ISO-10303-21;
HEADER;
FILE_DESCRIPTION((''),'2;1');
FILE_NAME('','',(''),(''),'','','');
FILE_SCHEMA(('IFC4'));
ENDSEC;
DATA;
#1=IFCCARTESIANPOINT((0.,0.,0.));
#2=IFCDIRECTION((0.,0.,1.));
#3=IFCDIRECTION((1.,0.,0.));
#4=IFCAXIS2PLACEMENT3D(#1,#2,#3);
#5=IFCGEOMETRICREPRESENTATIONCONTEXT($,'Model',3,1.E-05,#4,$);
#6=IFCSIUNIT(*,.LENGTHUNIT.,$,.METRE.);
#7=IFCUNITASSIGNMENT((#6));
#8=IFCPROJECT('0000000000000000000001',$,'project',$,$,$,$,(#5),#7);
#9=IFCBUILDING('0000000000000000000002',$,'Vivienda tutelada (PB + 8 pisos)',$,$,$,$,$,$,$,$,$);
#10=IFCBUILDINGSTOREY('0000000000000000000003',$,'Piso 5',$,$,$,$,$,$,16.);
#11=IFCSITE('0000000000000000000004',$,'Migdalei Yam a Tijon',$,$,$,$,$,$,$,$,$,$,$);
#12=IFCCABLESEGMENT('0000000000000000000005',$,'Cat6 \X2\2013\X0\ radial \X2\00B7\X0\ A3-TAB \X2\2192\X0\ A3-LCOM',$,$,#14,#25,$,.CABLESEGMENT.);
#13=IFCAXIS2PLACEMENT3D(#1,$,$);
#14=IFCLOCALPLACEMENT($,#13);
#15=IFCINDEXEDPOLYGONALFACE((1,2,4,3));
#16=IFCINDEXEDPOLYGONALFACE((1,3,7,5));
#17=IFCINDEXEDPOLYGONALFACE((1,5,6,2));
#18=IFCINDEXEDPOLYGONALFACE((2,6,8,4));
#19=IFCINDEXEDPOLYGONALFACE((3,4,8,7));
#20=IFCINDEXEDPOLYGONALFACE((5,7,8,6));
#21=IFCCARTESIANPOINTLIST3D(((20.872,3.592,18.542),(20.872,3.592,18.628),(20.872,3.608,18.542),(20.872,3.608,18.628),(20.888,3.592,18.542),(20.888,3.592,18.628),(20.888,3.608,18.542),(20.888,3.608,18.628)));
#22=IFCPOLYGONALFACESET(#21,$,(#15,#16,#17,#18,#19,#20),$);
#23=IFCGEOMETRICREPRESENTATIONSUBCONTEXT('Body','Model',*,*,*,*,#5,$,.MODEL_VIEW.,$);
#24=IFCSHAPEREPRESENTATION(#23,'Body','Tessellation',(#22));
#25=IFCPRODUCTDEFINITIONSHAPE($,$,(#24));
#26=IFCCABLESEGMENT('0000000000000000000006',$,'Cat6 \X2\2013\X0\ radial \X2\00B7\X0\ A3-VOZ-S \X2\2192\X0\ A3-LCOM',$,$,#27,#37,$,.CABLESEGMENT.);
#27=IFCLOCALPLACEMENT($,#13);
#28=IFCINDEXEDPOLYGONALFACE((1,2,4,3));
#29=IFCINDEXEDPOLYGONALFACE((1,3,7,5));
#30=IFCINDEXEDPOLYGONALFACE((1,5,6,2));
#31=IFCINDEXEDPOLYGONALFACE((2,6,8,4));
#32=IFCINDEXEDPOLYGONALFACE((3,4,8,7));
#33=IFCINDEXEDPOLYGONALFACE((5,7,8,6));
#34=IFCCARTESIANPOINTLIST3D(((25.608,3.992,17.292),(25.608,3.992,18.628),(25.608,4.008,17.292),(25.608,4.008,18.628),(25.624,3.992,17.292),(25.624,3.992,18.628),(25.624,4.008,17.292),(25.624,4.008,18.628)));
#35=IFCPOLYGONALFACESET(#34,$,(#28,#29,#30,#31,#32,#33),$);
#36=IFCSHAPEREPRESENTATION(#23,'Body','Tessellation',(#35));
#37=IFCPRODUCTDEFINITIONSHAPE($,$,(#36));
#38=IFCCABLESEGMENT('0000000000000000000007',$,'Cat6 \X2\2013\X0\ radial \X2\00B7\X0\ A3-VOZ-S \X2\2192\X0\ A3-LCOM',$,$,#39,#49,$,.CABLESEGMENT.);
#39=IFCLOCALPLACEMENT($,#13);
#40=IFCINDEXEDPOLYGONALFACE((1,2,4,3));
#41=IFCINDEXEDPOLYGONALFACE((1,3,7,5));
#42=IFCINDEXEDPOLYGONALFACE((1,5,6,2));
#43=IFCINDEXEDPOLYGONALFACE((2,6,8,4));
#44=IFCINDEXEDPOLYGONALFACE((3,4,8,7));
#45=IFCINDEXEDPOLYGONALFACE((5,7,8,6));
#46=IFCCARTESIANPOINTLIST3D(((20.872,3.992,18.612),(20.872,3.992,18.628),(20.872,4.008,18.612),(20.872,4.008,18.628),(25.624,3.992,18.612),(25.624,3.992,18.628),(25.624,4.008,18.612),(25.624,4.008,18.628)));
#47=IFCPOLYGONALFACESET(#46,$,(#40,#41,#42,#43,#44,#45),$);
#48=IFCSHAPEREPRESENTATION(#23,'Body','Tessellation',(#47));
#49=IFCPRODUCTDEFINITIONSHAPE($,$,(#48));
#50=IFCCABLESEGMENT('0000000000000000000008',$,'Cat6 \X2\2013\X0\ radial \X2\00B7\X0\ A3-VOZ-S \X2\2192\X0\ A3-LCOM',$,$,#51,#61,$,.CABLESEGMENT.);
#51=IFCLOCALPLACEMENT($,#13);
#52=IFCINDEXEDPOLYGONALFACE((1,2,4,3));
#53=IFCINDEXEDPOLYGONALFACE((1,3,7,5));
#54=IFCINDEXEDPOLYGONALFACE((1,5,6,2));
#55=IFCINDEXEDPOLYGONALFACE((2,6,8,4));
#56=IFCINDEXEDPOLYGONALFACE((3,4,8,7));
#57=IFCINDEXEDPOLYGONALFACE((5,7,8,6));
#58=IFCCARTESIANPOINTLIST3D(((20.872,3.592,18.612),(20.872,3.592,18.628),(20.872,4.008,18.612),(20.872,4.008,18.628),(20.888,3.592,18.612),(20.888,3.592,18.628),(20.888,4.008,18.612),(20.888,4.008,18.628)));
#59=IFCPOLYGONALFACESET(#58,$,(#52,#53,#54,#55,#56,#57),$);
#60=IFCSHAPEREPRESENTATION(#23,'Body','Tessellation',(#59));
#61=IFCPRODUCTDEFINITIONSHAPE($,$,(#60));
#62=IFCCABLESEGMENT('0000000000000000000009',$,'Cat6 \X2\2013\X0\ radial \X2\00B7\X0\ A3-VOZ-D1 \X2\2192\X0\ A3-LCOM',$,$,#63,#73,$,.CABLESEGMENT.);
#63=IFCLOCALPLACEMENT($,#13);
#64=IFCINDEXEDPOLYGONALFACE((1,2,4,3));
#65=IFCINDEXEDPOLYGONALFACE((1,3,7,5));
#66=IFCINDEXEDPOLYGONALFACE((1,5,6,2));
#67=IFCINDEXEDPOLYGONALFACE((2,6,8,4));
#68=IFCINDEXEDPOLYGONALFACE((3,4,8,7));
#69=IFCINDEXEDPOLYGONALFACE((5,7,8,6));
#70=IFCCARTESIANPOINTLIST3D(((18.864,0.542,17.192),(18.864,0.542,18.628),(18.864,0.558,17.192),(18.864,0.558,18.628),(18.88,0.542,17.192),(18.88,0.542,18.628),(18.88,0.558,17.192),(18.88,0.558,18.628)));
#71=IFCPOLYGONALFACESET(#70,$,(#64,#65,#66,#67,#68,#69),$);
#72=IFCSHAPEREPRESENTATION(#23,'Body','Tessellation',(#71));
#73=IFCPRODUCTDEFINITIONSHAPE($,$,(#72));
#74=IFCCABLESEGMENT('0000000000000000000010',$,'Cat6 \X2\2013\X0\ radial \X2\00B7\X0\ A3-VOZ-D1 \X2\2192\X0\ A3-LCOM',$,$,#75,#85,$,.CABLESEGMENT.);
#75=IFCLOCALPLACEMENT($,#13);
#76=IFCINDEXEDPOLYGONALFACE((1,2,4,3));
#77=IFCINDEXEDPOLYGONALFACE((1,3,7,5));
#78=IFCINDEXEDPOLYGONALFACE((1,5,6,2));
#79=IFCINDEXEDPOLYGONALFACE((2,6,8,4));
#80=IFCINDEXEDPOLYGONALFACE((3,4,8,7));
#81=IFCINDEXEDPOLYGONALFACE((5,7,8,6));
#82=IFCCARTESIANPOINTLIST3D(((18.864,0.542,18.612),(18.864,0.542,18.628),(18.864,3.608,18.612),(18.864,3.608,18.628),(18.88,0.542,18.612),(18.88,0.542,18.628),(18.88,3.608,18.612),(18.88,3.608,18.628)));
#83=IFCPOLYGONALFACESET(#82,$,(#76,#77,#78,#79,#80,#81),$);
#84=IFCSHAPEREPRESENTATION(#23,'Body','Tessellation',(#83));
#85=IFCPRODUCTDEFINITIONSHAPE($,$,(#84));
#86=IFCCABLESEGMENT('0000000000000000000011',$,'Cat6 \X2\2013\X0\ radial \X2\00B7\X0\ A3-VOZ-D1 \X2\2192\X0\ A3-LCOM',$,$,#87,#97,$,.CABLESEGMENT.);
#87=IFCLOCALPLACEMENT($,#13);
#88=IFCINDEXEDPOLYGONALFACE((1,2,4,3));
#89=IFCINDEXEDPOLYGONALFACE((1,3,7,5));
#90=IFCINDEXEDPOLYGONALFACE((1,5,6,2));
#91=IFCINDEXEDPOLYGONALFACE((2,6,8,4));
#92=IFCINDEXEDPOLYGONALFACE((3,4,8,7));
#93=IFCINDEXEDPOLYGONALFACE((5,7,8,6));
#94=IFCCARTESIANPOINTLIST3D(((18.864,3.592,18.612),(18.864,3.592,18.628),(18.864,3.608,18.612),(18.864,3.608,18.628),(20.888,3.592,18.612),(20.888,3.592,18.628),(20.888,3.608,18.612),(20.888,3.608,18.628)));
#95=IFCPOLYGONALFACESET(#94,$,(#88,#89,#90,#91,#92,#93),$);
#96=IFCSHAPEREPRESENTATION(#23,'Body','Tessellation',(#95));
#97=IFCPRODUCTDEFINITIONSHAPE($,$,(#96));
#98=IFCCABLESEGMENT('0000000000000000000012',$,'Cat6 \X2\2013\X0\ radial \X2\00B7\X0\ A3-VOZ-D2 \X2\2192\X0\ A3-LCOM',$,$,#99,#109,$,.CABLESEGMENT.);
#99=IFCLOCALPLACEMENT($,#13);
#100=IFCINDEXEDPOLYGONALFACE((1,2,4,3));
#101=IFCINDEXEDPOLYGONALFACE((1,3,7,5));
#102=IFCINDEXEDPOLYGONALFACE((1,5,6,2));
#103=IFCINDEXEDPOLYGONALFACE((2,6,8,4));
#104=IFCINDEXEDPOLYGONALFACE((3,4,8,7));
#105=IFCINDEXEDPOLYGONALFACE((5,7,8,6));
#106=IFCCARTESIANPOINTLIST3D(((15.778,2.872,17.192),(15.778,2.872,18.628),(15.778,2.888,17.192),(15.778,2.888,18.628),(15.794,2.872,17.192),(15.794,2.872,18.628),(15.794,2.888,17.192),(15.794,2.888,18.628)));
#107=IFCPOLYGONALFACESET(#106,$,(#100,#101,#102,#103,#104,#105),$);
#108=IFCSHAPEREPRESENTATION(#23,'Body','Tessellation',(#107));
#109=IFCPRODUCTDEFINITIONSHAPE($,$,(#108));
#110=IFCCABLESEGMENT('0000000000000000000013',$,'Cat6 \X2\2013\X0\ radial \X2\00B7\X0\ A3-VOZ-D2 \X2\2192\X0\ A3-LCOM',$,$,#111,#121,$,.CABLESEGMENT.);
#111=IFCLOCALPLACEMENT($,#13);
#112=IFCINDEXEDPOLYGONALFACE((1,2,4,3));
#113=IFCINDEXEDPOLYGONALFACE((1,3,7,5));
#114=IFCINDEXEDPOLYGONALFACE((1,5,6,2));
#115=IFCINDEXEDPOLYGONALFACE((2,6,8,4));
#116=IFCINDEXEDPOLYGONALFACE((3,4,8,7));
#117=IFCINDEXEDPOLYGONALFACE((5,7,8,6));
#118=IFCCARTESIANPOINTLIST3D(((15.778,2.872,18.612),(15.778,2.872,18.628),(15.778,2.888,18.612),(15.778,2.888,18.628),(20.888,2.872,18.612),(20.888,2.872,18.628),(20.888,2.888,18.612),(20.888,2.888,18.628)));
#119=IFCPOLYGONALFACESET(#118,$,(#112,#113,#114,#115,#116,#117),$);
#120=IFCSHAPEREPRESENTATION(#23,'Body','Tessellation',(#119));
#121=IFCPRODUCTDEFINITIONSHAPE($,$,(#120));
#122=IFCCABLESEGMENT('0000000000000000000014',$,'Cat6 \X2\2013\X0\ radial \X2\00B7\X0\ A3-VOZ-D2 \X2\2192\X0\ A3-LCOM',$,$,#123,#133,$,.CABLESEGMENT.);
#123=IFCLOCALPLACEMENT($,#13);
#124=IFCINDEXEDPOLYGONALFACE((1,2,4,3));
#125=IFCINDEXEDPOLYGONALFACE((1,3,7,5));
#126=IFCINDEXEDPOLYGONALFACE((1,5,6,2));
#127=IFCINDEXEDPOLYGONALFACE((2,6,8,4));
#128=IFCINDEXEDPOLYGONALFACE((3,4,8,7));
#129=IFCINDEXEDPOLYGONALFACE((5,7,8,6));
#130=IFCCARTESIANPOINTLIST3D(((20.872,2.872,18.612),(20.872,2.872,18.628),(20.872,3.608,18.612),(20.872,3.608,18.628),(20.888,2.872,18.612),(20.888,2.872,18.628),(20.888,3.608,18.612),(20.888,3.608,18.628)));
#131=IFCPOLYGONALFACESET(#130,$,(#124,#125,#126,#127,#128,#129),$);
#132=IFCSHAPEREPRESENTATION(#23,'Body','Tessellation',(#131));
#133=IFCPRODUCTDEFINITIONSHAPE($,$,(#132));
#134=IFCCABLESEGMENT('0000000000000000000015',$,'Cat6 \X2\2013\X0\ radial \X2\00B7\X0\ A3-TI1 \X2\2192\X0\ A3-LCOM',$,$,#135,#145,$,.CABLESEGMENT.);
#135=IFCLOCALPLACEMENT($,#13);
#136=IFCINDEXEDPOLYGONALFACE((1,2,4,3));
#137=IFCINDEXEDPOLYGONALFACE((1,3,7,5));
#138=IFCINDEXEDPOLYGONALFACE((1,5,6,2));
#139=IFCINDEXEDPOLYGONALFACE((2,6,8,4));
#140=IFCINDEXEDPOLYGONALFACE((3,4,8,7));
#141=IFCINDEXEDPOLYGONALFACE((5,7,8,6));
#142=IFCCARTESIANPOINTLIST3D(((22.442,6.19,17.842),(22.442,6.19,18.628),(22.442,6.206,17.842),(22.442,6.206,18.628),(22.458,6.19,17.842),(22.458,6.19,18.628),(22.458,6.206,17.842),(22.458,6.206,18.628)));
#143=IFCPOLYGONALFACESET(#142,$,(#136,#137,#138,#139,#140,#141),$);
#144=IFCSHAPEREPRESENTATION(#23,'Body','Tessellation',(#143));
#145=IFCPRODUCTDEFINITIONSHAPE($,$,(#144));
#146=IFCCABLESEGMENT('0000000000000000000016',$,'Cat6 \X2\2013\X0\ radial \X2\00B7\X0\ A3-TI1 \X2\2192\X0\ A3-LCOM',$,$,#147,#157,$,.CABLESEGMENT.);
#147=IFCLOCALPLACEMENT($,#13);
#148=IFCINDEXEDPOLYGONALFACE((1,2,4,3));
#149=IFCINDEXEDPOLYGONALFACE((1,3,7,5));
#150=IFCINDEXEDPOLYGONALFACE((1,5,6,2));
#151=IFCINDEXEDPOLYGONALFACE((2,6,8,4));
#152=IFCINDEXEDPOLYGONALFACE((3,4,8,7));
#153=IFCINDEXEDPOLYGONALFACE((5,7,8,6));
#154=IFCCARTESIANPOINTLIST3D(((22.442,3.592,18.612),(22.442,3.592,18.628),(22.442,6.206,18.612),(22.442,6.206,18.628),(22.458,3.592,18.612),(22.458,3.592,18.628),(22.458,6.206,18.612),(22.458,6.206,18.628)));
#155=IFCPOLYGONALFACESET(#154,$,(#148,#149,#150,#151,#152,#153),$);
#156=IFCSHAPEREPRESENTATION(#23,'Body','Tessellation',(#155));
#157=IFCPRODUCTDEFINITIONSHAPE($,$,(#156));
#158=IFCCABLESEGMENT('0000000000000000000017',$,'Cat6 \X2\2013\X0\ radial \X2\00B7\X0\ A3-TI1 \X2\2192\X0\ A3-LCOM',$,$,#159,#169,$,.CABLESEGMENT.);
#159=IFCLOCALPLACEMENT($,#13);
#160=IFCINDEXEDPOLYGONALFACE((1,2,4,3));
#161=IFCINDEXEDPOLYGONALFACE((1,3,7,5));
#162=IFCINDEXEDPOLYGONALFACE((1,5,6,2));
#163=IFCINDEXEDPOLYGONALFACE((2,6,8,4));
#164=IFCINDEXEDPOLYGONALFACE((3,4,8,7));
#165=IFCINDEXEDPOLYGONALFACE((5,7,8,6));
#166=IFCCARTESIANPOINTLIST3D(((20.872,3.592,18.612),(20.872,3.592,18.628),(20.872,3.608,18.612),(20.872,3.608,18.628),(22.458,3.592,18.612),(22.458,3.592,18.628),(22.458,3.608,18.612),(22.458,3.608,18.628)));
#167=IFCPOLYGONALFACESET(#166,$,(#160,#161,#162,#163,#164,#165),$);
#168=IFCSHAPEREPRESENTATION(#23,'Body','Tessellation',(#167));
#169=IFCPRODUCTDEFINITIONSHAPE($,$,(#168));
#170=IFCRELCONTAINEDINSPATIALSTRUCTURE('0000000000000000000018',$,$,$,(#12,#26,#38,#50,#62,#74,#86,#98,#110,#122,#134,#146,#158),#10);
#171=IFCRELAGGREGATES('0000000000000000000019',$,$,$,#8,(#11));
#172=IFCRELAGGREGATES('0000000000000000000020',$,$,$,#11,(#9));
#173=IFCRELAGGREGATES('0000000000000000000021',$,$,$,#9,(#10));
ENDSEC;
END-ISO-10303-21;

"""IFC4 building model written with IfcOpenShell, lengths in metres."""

from ifc_helpers import new_model, si_unit, frame, origin_with_axes, context, subcontext, project, spatial, line, indexed_curve, outline, extrude, element, save


model = new_model("IFC4")

# Units and contexts
model_context = context("Model", 3, precision=1e-05, world=origin_with_axes())
body_context = subcontext(model_context, "Body", "Model", "MODEL_VIEW")
ifc_project = project(units=[si_unit("LENGTHUNIT", "METRE")], contexts=[model_context])

# Site, building, storey
site = spatial("IfcSite", under=ifc_project, Name="Migdalei Yam a Tijon")
building = spatial("IfcBuilding", under=site, Name="Vivienda tutelada (PB + 8 pisos)")
storey = spatial("IfcBuildingStorey", under=building, Name="Piso 5", Elevation=16.0)

# Cable segments
element("IfcCableSegment", 1, inside=storey, Name="Cat6 – radial · A3-TAB → A3-LCOM", PredefinedType="CABLESEGMENT", context=body_context, shape_type="SweptSolid", body=[
    extrude(outline(indexed_curve([(0.0, 0.0), (0.016, 0.0), (0.016, 0.016), (0.0, 0.016)], segments=[line(1, 2, 3, 4, 1)])), frame((20.872, 3.592, 18.542), z_axis=(0.0, 0.0, 1.0), x_axis=(1.0, 0.0, 0.0)), (0.0, 0.0, 1.0), 0.086),
])
element("IfcCableSegment", 2, inside=storey, Name="Cat6 – radial · A3-VOZ-S → A3-LCOM", PredefinedType="CABLESEGMENT", context=body_context, shape_type="SweptSolid", body=[
    extrude(outline(indexed_curve([(0.0, 0.0), (0.016, 0.0), (0.016, 0.016), (0.0, 0.016)], segments=[line(1, 2, 3, 4, 1)])), frame((25.608, 3.992, 17.292), z_axis=(0.0, 0.0, 1.0), x_axis=(1.0, 0.0, 0.0)), (0.0, 0.0, 1.0), 1.336),
])
element("IfcCableSegment", 3, inside=storey, Name="Cat6 – radial · A3-VOZ-S → A3-LCOM", PredefinedType="CABLESEGMENT", context=body_context, shape_type="SweptSolid", body=[
    extrude(outline(indexed_curve([(0.0, 0.0), (4.752, 0.0), (4.752, 0.016), (0.0, 0.016)], segments=[line(1, 2, 3, 4, 1)])), frame((20.872, 3.992, 18.612), z_axis=(0.0, 0.0, 1.0), x_axis=(1.0, 0.0, 0.0)), (0.0, 0.0, 1.0), 0.016),
])
element("IfcCableSegment", 4, inside=storey, Name="Cat6 – radial · A3-VOZ-S → A3-LCOM", PredefinedType="CABLESEGMENT", context=body_context, shape_type="SweptSolid", body=[
    extrude(outline(indexed_curve([(0.0, 0.0), (0.016, 0.0), (0.016, 0.416), (0.0, 0.416)], segments=[line(1, 2, 3, 4, 1)])), frame((20.872, 3.592, 18.612), z_axis=(0.0, 0.0, 1.0), x_axis=(1.0, 0.0, 0.0)), (0.0, 0.0, 1.0), 0.016),
])
element("IfcCableSegment", 5, inside=storey, Name="Cat6 – radial · A3-VOZ-D1 → A3-LCOM", PredefinedType="CABLESEGMENT", context=body_context, shape_type="SweptSolid", body=[
    extrude(outline(indexed_curve([(0.0, 0.0), (0.016, 0.0), (0.016, 0.016), (0.0, 0.016)], segments=[line(1, 2, 3, 4, 1)])), frame((18.864, 0.542, 17.192), z_axis=(0.0, 0.0, 1.0), x_axis=(1.0, 0.0, 0.0)), (0.0, 0.0, 1.0), 1.436),
])
element("IfcCableSegment", 6, inside=storey, Name="Cat6 – radial · A3-VOZ-D1 → A3-LCOM", PredefinedType="CABLESEGMENT", context=body_context, shape_type="SweptSolid", body=[
    extrude(outline(indexed_curve([(0.0, 0.0), (0.016, 0.0), (0.016, 3.066), (0.0, 3.066)], segments=[line(1, 2, 3, 4, 1)])), frame((18.864, 0.542, 18.612), z_axis=(0.0, 0.0, 1.0), x_axis=(1.0, 0.0, 0.0)), (0.0, 0.0, 1.0), 0.016),
])
element("IfcCableSegment", 7, inside=storey, Name="Cat6 – radial · A3-VOZ-D1 → A3-LCOM", PredefinedType="CABLESEGMENT", context=body_context, shape_type="SweptSolid", body=[
    extrude(outline(indexed_curve([(0.0, 0.0), (2.024, 0.0), (2.024, 0.016), (0.0, 0.016)], segments=[line(1, 2, 3, 4, 1)])), frame((18.864, 3.592, 18.612), z_axis=(0.0, 0.0, 1.0), x_axis=(1.0, 0.0, 0.0)), (0.0, 0.0, 1.0), 0.016),
])
element("IfcCableSegment", 8, inside=storey, Name="Cat6 – radial · A3-VOZ-D2 → A3-LCOM", PredefinedType="CABLESEGMENT", context=body_context, shape_type="SweptSolid", body=[
    extrude(outline(indexed_curve([(0.0, 0.0), (0.016, 0.0), (0.016, 0.016), (0.0, 0.016)], segments=[line(1, 2, 3, 4, 1)])), frame((15.778, 2.872, 17.192), z_axis=(0.0, 0.0, 1.0), x_axis=(1.0, 0.0, 0.0)), (0.0, 0.0, 1.0), 1.436),
])
element("IfcCableSegment", 9, inside=storey, Name="Cat6 – radial · A3-VOZ-D2 → A3-LCOM", PredefinedType="CABLESEGMENT", context=body_context, shape_type="SweptSolid", body=[
    extrude(outline(indexed_curve([(0.0, 0.0), (5.11, 0.0), (5.11, 0.016), (0.0, 0.016)], segments=[line(1, 2, 3, 4, 1)])), frame((15.778, 2.872, 18.612), z_axis=(0.0, 0.0, 1.0), x_axis=(1.0, 0.0, 0.0)), (0.0, 0.0, 1.0), 0.016),
])
element("IfcCableSegment", 10, inside=storey, Name="Cat6 – radial · A3-VOZ-D2 → A3-LCOM", PredefinedType="CABLESEGMENT", context=body_context, shape_type="SweptSolid", body=[
    extrude(outline(indexed_curve([(0.0, 0.0), (0.016, 0.0), (0.016, 0.736), (0.0, 0.736)], segments=[line(1, 2, 3, 4, 1)])), frame((20.872, 2.872, 18.612), z_axis=(0.0, 0.0, 1.0), x_axis=(1.0, 0.0, 0.0)), (0.0, 0.0, 1.0), 0.016),
])
element("IfcCableSegment", 11, inside=storey, Name="Cat6 – radial · A3-TI1 → A3-LCOM", PredefinedType="CABLESEGMENT", context=body_context, shape_type="SweptSolid", body=[
    extrude(outline(indexed_curve([(0.0, 0.0), (0.016, 0.0), (0.016, 0.016), (0.0, 0.016)], segments=[line(1, 2, 3, 4, 1)])), frame((22.442, 6.19, 17.842), z_axis=(0.0, 0.0, 1.0), x_axis=(1.0, 0.0, 0.0)), (0.0, 0.0, 1.0), 0.786),
])
element("IfcCableSegment", 12, inside=storey, Name="Cat6 – radial · A3-TI1 → A3-LCOM", PredefinedType="CABLESEGMENT", context=body_context, shape_type="SweptSolid", body=[
    extrude(outline(indexed_curve([(0.0, 0.0), (0.016, 0.0), (0.016, 2.614), (0.0, 2.614)], segments=[line(1, 2, 3, 4, 1)])), frame((22.442, 3.592, 18.612), z_axis=(0.0, 0.0, 1.0), x_axis=(1.0, 0.0, 0.0)), (0.0, 0.0, 1.0), 0.016),
])
element("IfcCableSegment", 13, inside=storey, Name="Cat6 – radial · A3-TI1 → A3-LCOM", PredefinedType="CABLESEGMENT", context=body_context, shape_type="SweptSolid", body=[
    extrude(outline(indexed_curve([(0.0, 0.0), (1.586, 0.0), (1.586, 0.016), (0.0, 0.016)], segments=[line(1, 2, 3, 4, 1)])), frame((20.872, 3.592, 18.612), z_axis=(0.0, 0.0, 1.0), x_axis=(1.0, 0.0, 0.0)), (0.0, 0.0, 1.0), 0.016),
])

save(model, "model.ifc")
